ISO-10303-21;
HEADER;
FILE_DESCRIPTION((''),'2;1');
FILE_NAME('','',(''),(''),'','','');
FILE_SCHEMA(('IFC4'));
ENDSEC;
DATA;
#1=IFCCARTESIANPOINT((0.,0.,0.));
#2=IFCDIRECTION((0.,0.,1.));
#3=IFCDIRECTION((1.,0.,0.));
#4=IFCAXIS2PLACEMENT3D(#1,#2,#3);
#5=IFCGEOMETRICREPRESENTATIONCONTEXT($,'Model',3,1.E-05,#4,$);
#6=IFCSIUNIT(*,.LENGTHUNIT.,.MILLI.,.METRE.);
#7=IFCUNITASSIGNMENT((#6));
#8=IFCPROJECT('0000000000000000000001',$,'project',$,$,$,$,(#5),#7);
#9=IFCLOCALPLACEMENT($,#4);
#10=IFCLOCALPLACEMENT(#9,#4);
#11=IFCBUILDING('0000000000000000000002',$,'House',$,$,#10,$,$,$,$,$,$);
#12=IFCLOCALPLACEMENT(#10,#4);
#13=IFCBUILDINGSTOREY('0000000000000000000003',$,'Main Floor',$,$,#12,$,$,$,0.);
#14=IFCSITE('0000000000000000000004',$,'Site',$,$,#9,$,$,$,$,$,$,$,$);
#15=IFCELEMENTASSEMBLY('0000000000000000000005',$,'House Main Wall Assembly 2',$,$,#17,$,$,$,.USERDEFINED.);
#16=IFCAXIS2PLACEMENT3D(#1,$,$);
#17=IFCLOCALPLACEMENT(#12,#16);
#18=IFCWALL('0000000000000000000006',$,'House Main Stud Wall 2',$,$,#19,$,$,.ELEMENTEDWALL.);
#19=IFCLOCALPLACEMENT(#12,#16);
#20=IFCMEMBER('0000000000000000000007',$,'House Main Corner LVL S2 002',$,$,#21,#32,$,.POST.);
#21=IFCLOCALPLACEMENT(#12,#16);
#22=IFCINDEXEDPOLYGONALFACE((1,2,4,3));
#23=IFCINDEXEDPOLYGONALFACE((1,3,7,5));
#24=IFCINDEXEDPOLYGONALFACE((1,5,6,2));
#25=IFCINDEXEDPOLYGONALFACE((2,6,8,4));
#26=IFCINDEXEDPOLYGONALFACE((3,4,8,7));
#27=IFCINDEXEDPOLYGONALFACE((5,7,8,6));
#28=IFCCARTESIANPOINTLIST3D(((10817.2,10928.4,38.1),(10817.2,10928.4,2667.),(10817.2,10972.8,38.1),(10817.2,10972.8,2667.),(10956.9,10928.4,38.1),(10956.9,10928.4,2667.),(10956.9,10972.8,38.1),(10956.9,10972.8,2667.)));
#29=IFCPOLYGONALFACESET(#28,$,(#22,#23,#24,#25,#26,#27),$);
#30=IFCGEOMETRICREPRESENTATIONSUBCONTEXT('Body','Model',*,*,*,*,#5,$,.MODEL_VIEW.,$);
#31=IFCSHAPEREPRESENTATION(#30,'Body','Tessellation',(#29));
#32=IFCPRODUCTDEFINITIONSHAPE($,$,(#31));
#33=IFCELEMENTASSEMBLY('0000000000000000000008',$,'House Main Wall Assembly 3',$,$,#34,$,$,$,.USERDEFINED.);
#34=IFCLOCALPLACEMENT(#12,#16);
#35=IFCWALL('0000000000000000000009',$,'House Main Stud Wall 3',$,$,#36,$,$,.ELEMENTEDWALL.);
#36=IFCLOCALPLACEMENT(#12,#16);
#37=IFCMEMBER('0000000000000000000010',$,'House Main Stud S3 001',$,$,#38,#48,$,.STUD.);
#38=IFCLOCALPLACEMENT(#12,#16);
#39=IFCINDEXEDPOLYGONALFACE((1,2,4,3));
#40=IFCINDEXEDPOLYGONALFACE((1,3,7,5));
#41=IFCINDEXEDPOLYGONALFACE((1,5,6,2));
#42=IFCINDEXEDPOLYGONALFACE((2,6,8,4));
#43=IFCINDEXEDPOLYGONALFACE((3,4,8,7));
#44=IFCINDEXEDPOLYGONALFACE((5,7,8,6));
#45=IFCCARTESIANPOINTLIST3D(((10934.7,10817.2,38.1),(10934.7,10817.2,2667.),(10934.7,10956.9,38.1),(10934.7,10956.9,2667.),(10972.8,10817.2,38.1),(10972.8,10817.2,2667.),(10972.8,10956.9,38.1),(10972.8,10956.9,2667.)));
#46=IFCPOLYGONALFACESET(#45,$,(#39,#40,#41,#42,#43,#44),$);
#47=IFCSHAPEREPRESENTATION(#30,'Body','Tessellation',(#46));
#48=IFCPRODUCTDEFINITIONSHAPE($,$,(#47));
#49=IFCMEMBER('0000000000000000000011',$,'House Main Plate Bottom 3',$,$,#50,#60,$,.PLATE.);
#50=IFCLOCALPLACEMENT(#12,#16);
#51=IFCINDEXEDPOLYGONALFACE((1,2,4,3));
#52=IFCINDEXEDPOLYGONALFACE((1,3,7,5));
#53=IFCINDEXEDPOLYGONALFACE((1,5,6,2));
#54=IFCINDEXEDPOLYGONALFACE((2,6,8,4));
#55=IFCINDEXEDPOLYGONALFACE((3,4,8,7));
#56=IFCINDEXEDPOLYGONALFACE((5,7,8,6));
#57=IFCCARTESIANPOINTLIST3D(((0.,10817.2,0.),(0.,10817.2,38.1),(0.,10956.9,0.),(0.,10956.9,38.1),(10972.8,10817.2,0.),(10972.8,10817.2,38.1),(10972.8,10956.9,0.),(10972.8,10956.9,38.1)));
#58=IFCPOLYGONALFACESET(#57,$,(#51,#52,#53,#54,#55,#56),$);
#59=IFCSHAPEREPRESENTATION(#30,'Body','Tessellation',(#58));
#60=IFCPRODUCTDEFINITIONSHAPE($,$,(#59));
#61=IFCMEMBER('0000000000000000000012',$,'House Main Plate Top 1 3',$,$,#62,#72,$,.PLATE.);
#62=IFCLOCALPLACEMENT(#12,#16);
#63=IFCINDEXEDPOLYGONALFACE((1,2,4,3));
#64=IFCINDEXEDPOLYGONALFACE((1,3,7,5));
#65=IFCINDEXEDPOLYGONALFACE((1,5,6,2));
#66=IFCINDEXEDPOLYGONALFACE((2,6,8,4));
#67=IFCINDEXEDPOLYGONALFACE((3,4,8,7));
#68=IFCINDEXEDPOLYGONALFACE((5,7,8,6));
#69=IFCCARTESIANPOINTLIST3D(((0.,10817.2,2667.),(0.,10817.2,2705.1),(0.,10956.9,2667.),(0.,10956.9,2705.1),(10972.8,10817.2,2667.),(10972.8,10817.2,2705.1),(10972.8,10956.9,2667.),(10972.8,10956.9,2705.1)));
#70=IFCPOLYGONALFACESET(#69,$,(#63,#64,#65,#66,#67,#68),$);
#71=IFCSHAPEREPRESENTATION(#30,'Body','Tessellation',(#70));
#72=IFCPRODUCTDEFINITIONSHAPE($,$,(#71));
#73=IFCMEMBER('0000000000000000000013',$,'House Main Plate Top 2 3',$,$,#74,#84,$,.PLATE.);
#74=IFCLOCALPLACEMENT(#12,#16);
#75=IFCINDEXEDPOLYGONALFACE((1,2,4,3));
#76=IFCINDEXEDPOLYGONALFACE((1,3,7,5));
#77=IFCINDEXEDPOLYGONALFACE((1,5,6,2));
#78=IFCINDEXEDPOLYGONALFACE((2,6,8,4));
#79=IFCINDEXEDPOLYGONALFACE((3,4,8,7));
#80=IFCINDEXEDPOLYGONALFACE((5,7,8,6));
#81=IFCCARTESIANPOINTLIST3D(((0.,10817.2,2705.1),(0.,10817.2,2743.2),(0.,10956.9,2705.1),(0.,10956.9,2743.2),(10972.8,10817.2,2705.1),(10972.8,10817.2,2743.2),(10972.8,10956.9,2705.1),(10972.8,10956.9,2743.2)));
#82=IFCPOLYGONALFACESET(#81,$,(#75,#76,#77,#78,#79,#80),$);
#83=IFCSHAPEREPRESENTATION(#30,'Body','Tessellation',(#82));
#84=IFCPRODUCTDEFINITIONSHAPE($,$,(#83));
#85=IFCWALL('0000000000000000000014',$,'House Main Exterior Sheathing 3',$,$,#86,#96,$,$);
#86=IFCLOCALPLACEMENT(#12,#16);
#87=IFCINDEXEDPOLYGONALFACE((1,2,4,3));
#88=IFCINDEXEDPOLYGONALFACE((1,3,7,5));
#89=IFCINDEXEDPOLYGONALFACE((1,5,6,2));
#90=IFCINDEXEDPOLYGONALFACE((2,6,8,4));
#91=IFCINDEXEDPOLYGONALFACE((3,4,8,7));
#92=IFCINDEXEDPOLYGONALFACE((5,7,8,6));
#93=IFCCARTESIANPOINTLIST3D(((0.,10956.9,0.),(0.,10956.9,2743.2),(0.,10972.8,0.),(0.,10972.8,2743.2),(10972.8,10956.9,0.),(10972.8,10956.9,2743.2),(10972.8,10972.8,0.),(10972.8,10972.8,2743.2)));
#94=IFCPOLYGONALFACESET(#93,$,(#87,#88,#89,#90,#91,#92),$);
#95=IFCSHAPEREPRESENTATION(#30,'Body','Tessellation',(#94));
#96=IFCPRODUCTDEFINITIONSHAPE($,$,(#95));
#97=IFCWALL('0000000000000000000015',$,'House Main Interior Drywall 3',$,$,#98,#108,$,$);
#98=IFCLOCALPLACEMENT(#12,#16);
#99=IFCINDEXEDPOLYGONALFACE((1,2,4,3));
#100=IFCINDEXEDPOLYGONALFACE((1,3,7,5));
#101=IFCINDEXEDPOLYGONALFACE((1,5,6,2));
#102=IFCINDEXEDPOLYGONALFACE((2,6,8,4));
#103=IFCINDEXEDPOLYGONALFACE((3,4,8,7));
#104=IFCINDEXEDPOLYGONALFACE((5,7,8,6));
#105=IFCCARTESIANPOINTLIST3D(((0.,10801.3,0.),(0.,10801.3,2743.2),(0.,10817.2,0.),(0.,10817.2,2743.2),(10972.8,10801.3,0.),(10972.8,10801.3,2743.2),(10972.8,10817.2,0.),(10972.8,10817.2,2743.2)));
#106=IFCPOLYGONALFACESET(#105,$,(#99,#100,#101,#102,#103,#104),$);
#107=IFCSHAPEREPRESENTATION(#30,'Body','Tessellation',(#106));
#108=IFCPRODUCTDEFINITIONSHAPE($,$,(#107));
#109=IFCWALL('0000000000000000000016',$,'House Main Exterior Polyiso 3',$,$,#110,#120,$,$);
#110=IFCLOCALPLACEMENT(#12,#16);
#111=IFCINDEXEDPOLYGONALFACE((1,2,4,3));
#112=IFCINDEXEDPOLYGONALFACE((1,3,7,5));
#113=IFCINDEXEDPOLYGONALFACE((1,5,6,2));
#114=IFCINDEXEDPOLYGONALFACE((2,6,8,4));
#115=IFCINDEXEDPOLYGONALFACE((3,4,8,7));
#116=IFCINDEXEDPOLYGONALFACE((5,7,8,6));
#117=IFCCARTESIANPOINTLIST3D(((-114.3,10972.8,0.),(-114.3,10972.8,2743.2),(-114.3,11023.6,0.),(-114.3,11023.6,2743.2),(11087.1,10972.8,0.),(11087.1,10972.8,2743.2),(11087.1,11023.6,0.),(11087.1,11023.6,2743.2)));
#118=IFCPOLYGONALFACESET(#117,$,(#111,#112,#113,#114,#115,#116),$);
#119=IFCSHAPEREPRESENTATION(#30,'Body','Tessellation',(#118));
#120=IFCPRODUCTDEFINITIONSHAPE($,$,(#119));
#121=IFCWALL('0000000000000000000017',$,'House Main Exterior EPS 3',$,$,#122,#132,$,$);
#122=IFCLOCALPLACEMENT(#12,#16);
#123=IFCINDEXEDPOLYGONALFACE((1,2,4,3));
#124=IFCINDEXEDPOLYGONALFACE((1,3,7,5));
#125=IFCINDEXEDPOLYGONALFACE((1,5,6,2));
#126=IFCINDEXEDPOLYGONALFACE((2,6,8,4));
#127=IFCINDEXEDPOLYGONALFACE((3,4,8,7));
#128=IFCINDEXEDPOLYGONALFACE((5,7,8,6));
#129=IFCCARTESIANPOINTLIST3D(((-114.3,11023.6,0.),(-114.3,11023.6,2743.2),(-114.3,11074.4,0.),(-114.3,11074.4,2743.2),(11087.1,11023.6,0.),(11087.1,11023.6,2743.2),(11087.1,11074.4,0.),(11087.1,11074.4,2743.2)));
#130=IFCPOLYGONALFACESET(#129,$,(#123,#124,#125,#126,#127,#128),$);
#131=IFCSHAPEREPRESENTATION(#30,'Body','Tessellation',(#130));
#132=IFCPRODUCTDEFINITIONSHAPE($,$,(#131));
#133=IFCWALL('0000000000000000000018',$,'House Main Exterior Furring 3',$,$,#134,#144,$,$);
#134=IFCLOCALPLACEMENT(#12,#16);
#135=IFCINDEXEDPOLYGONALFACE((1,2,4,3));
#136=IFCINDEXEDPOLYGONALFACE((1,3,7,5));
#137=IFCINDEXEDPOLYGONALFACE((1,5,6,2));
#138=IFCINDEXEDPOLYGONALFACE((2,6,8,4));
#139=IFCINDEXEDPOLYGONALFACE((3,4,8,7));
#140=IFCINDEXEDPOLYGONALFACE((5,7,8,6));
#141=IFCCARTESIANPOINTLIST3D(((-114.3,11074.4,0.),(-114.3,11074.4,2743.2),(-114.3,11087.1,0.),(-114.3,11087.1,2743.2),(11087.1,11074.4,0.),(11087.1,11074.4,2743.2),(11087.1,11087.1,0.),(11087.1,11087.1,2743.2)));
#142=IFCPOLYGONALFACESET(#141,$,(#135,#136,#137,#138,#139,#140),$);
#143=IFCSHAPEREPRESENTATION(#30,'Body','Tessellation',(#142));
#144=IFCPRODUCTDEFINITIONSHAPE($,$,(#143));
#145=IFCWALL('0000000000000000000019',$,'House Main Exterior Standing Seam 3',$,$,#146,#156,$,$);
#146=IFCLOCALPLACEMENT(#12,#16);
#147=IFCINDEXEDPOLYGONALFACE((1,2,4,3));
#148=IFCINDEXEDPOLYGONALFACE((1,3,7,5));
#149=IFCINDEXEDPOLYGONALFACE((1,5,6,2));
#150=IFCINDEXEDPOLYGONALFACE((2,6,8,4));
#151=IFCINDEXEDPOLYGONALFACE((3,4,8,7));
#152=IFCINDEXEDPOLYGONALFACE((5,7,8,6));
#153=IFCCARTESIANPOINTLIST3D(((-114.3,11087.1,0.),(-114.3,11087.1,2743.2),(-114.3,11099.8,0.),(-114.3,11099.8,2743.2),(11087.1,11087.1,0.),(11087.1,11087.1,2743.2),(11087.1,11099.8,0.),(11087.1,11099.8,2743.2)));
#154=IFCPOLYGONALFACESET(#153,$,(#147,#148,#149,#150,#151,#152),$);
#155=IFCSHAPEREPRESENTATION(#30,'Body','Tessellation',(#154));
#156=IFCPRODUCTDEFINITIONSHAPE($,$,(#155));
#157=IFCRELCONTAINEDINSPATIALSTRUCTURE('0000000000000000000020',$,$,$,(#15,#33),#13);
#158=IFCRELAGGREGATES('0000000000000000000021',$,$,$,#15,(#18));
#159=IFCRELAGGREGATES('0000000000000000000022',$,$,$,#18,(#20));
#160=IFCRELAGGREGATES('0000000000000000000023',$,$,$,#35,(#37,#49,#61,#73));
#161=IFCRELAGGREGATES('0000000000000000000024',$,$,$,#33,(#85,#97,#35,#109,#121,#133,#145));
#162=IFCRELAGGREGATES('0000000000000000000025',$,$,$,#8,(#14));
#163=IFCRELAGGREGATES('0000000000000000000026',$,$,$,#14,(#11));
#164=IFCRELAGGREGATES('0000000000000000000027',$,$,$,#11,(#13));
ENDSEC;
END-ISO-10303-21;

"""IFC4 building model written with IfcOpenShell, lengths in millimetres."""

from ifc_helpers import new_model, si_unit, frame, origin_with_axes, origin_2d, place, context, subcontext, project, spatial, indexed_curve, rectangle, outline, extrude, element, aggregate, save


model = new_model("IFC4")

# Units and contexts
model_context = context("Model", 3, precision=1e-05, world=origin_with_axes())
body_context = subcontext(model_context, "Body", "Model", "MODEL_VIEW")
ifc_project = project(units=[si_unit("LENGTHUNIT", "METRE", prefix="MILLI")], contexts=[model_context])

# Site, building, storey
site_placement = place(None, origin_with_axes())
site = spatial("IfcSite", under=ifc_project, at=site_placement, Name="Site")
building_placement = place(site_placement, origin_with_axes())
building = spatial("IfcBuilding", under=site, at=building_placement, Name="House")
storey_placement = place(building_placement, origin_with_axes())
storey = spatial("IfcBuildingStorey", under=building, at=storey_placement, Name="Main Floor", Elevation=0.0)

# Element assembly, wall, member
assembly_1_placement = place(storey_placement, origin_with_axes())
assembly_1 = element("IfcElementAssembly", 1, at=assembly_1_placement, inside=storey, Name="House Main Wall Assembly 2", PredefinedType="USERDEFINED")
wall_1_placement = place(assembly_1_placement, frame((10972.8, 0.0, 0.0), z_axis=(0.0, 0.0, 1.0), x_axis=(0.0, 1.0, 0.0)))
wall_1 = element("IfcWall", 2, at=wall_1_placement, Name="House Main Stud Wall 2", PredefinedType="ELEMENTEDWALL")
aggregate(assembly_1, [wall_1])
member_1_placement = place(wall_1_placement, frame((10950.6, 85.7, 38.1), z_axis=(0.0, 0.0, 1.0), x_axis=(1.0, 0.0, 0.0)))
member_1 = element("IfcMember", 3, at=member_1_placement, Name="House Main Corner LVL S2 002", PredefinedType="POST", context=body_context, shape_type="SweptSolid", body=[
    extrude(rectangle(XDim=44.5, YDim=139.7, at=origin_2d()), origin_with_axes(), (0.0, 0.0, 1.0), 2628.9),
])
aggregate(wall_1, [member_1])

# Element assembly, walls, members
assembly_2_placement = place(storey_placement, origin_with_axes())
assembly_2 = element("IfcElementAssembly", 4, at=assembly_2_placement, inside=storey, Name="House Main Wall Assembly 3", PredefinedType="USERDEFINED")
wall_2_placement = place(assembly_2_placement, frame((10972.8, 10972.8, 0.0), z_axis=(0.0, 0.0, 1.0), x_axis=(-1.0, 0.0, 0.0)))
wall_2 = element("IfcWall", 5, at=wall_2_placement, Name="House Main Stud Wall 3", PredefinedType="ELEMENTEDWALL")
member_2_placement = place(wall_2_placement, frame((19.1, 85.7, 38.1), z_axis=(0.0, 0.0, 1.0), x_axis=(1.0, 0.0, 0.0)))
member_2 = element("IfcMember", 6, at=member_2_placement, Name="House Main Stud S3 001", PredefinedType="STUD", context=body_context, shape_type="SweptSolid", body=[
    extrude(rectangle(XDim=38.1, YDim=139.7, at=origin_2d()), origin_with_axes(), (0.0, 0.0, 1.0), 2628.9),
])
member_3_placement = place(wall_2_placement, frame((0.0, 85.7, 19.1), z_axis=(1.0, 0.0, 0.0), x_axis=(0.0, 0.0, 1.0)))
member_3 = element("IfcMember", 7, at=member_3_placement, Name="House Main Plate Bottom 3", PredefinedType="PLATE", context=body_context, shape_type="SweptSolid", body=[
    extrude(rectangle(XDim=38.1, YDim=139.7, at=origin_2d()), origin_with_axes(), (0.0, 0.0, 1.0), 10972.8),
])
member_4_placement = place(wall_2_placement, frame((0.0, 85.7, 2686.1), z_axis=(1.0, 0.0, 0.0), x_axis=(0.0, 0.0, 1.0)))
member_4 = element("IfcMember", 8, at=member_4_placement, Name="House Main Plate Top 1 3", PredefinedType="PLATE", context=body_context, shape_type="SweptSolid", body=[
    extrude(rectangle(XDim=38.1, YDim=139.7, at=origin_2d()), origin_with_axes(), (0.0, 0.0, 1.0), 10972.8),
])
member_5_placement = place(wall_2_placement, frame((0.0, 85.7, 2724.2), z_axis=(1.0, 0.0, 0.0), x_axis=(0.0, 0.0, 1.0)))
member_5 = element("IfcMember", 9, at=member_5_placement, Name="House Main Plate Top 2 3", PredefinedType="PLATE", context=body_context, shape_type="SweptSolid", body=[
    extrude(rectangle(XDim=38.1, YDim=139.7, at=origin_2d()), origin_with_axes(), (0.0, 0.0, 1.0), 10972.8),
])
aggregate(wall_2, [member_2, member_3, member_4, member_5])
wall_3_placement = place(assembly_2_placement, frame((10972.8, 10972.8, 0.0), z_axis=(0.0, 0.0, 1.0), x_axis=(-1.0, 0.0, 0.0)))
wall_3 = element("IfcWall", 10, at=wall_3_placement, Name="House Main Exterior Sheathing 3", context=body_context, shape_type="SweptSolid", body=[
    extrude(outline(indexed_curve([(0.0, 0.0), (0.0, 15.9), (10972.8, 15.9), (10972.8, 0.0), (0.0, 0.0)], self_intersect=False)), origin_with_axes(), (0.0, 0.0, 1.0), 2743.2),
])
wall_4_placement = place(assembly_2_placement, frame((10972.8, 10972.8, 0.0), z_axis=(0.0, 0.0, 1.0), x_axis=(-1.0, 0.0, 0.0)))
wall_4 = element("IfcWall", 11, at=wall_4_placement, Name="House Main Interior Drywall 3", context=body_context, shape_type="SweptSolid", body=[
    extrude(outline(indexed_curve([(0.0, 0.0), (0.0, 15.9), (10972.8, 15.9), (10972.8, 0.0), (0.0, 0.0)], self_intersect=False)), frame((0.0, 155.6, 0.0), z_axis=(0.0, 0.0, 1.0), x_axis=(1.0, 0.0, 0.0)), (0.0, 0.0, 1.0), 2743.2),
])
wall_5_placement = place(assembly_2_placement, frame((11087.1, 10972.8, 0.0), z_axis=(0.0, 0.0, 1.0), x_axis=(-1.0, 0.0, 0.0)))
wall_5 = element("IfcWall", 12, at=wall_5_placement, Name="House Main Exterior Polyiso 3", context=body_context, shape_type="SweptSolid", body=[
    extrude(outline(indexed_curve([(0.0, 0.0), (0.0, -50.8), (11201.4, -50.8), (11201.4, 0.0), (0.0, 0.0)], self_intersect=False)), origin_with_axes(), (0.0, 0.0, 1.0), 2743.2),
])
wall_6_placement = place(assembly_2_placement, frame((11087.1, 10972.8, 0.0), z_axis=(0.0, 0.0, 1.0), x_axis=(-1.0, 0.0, 0.0)))
wall_6 = element("IfcWall", 13, at=wall_6_placement, Name="House Main Exterior EPS 3", context=body_context, shape_type="SweptSolid", body=[
    extrude(outline(indexed_curve([(0.0, 0.0), (0.0, -50.8), (11201.4, -50.8), (11201.4, 0.0), (0.0, 0.0)], self_intersect=False)), frame((0.0, -50.8, 0.0), z_axis=(0.0, 0.0, 1.0), x_axis=(1.0, 0.0, 0.0)), (0.0, 0.0, 1.0), 2743.2),
])
wall_7_placement = place(assembly_2_placement, frame((11087.1, 10972.8, 0.0), z_axis=(0.0, 0.0, 1.0), x_axis=(-1.0, 0.0, 0.0)))
wall_7 = element("IfcWall", 14, at=wall_7_placement, Name="House Main Exterior Furring 3", context=body_context, shape_type="SweptSolid", body=[
    extrude(outline(indexed_curve([(0.0, 0.0), (0.0, -12.7), (11201.4, -12.7), (11201.4, 0.0), (0.0, 0.0)], self_intersect=False)), frame((0.0, -101.6, 0.0), z_axis=(0.0, 0.0, 1.0), x_axis=(1.0, 0.0, 0.0)), (0.0, 0.0, 1.0), 2743.2),
])
wall_8_placement = place(assembly_2_placement, frame((11087.1, 10972.8, 0.0), z_axis=(0.0, 0.0, 1.0), x_axis=(-1.0, 0.0, 0.0)))
wall_8 = element("IfcWall", 15, at=wall_8_placement, Name="House Main Exterior Standing Seam 3", context=body_context, shape_type="SweptSolid", body=[
    extrude(outline(indexed_curve([(0.0, 0.0), (0.0, -12.7), (11201.4, -12.7), (11201.4, 0.0), (0.0, 0.0)], self_intersect=False)), frame((0.0, -114.3, 0.0), z_axis=(0.0, 0.0, 1.0), x_axis=(1.0, 0.0, 0.0)), (0.0, 0.0, 1.0), 2743.2),
])
aggregate(assembly_2, [wall_3, wall_4, wall_2, wall_5, wall_6, wall_7, wall_8])

save(model, "model.ifc")
